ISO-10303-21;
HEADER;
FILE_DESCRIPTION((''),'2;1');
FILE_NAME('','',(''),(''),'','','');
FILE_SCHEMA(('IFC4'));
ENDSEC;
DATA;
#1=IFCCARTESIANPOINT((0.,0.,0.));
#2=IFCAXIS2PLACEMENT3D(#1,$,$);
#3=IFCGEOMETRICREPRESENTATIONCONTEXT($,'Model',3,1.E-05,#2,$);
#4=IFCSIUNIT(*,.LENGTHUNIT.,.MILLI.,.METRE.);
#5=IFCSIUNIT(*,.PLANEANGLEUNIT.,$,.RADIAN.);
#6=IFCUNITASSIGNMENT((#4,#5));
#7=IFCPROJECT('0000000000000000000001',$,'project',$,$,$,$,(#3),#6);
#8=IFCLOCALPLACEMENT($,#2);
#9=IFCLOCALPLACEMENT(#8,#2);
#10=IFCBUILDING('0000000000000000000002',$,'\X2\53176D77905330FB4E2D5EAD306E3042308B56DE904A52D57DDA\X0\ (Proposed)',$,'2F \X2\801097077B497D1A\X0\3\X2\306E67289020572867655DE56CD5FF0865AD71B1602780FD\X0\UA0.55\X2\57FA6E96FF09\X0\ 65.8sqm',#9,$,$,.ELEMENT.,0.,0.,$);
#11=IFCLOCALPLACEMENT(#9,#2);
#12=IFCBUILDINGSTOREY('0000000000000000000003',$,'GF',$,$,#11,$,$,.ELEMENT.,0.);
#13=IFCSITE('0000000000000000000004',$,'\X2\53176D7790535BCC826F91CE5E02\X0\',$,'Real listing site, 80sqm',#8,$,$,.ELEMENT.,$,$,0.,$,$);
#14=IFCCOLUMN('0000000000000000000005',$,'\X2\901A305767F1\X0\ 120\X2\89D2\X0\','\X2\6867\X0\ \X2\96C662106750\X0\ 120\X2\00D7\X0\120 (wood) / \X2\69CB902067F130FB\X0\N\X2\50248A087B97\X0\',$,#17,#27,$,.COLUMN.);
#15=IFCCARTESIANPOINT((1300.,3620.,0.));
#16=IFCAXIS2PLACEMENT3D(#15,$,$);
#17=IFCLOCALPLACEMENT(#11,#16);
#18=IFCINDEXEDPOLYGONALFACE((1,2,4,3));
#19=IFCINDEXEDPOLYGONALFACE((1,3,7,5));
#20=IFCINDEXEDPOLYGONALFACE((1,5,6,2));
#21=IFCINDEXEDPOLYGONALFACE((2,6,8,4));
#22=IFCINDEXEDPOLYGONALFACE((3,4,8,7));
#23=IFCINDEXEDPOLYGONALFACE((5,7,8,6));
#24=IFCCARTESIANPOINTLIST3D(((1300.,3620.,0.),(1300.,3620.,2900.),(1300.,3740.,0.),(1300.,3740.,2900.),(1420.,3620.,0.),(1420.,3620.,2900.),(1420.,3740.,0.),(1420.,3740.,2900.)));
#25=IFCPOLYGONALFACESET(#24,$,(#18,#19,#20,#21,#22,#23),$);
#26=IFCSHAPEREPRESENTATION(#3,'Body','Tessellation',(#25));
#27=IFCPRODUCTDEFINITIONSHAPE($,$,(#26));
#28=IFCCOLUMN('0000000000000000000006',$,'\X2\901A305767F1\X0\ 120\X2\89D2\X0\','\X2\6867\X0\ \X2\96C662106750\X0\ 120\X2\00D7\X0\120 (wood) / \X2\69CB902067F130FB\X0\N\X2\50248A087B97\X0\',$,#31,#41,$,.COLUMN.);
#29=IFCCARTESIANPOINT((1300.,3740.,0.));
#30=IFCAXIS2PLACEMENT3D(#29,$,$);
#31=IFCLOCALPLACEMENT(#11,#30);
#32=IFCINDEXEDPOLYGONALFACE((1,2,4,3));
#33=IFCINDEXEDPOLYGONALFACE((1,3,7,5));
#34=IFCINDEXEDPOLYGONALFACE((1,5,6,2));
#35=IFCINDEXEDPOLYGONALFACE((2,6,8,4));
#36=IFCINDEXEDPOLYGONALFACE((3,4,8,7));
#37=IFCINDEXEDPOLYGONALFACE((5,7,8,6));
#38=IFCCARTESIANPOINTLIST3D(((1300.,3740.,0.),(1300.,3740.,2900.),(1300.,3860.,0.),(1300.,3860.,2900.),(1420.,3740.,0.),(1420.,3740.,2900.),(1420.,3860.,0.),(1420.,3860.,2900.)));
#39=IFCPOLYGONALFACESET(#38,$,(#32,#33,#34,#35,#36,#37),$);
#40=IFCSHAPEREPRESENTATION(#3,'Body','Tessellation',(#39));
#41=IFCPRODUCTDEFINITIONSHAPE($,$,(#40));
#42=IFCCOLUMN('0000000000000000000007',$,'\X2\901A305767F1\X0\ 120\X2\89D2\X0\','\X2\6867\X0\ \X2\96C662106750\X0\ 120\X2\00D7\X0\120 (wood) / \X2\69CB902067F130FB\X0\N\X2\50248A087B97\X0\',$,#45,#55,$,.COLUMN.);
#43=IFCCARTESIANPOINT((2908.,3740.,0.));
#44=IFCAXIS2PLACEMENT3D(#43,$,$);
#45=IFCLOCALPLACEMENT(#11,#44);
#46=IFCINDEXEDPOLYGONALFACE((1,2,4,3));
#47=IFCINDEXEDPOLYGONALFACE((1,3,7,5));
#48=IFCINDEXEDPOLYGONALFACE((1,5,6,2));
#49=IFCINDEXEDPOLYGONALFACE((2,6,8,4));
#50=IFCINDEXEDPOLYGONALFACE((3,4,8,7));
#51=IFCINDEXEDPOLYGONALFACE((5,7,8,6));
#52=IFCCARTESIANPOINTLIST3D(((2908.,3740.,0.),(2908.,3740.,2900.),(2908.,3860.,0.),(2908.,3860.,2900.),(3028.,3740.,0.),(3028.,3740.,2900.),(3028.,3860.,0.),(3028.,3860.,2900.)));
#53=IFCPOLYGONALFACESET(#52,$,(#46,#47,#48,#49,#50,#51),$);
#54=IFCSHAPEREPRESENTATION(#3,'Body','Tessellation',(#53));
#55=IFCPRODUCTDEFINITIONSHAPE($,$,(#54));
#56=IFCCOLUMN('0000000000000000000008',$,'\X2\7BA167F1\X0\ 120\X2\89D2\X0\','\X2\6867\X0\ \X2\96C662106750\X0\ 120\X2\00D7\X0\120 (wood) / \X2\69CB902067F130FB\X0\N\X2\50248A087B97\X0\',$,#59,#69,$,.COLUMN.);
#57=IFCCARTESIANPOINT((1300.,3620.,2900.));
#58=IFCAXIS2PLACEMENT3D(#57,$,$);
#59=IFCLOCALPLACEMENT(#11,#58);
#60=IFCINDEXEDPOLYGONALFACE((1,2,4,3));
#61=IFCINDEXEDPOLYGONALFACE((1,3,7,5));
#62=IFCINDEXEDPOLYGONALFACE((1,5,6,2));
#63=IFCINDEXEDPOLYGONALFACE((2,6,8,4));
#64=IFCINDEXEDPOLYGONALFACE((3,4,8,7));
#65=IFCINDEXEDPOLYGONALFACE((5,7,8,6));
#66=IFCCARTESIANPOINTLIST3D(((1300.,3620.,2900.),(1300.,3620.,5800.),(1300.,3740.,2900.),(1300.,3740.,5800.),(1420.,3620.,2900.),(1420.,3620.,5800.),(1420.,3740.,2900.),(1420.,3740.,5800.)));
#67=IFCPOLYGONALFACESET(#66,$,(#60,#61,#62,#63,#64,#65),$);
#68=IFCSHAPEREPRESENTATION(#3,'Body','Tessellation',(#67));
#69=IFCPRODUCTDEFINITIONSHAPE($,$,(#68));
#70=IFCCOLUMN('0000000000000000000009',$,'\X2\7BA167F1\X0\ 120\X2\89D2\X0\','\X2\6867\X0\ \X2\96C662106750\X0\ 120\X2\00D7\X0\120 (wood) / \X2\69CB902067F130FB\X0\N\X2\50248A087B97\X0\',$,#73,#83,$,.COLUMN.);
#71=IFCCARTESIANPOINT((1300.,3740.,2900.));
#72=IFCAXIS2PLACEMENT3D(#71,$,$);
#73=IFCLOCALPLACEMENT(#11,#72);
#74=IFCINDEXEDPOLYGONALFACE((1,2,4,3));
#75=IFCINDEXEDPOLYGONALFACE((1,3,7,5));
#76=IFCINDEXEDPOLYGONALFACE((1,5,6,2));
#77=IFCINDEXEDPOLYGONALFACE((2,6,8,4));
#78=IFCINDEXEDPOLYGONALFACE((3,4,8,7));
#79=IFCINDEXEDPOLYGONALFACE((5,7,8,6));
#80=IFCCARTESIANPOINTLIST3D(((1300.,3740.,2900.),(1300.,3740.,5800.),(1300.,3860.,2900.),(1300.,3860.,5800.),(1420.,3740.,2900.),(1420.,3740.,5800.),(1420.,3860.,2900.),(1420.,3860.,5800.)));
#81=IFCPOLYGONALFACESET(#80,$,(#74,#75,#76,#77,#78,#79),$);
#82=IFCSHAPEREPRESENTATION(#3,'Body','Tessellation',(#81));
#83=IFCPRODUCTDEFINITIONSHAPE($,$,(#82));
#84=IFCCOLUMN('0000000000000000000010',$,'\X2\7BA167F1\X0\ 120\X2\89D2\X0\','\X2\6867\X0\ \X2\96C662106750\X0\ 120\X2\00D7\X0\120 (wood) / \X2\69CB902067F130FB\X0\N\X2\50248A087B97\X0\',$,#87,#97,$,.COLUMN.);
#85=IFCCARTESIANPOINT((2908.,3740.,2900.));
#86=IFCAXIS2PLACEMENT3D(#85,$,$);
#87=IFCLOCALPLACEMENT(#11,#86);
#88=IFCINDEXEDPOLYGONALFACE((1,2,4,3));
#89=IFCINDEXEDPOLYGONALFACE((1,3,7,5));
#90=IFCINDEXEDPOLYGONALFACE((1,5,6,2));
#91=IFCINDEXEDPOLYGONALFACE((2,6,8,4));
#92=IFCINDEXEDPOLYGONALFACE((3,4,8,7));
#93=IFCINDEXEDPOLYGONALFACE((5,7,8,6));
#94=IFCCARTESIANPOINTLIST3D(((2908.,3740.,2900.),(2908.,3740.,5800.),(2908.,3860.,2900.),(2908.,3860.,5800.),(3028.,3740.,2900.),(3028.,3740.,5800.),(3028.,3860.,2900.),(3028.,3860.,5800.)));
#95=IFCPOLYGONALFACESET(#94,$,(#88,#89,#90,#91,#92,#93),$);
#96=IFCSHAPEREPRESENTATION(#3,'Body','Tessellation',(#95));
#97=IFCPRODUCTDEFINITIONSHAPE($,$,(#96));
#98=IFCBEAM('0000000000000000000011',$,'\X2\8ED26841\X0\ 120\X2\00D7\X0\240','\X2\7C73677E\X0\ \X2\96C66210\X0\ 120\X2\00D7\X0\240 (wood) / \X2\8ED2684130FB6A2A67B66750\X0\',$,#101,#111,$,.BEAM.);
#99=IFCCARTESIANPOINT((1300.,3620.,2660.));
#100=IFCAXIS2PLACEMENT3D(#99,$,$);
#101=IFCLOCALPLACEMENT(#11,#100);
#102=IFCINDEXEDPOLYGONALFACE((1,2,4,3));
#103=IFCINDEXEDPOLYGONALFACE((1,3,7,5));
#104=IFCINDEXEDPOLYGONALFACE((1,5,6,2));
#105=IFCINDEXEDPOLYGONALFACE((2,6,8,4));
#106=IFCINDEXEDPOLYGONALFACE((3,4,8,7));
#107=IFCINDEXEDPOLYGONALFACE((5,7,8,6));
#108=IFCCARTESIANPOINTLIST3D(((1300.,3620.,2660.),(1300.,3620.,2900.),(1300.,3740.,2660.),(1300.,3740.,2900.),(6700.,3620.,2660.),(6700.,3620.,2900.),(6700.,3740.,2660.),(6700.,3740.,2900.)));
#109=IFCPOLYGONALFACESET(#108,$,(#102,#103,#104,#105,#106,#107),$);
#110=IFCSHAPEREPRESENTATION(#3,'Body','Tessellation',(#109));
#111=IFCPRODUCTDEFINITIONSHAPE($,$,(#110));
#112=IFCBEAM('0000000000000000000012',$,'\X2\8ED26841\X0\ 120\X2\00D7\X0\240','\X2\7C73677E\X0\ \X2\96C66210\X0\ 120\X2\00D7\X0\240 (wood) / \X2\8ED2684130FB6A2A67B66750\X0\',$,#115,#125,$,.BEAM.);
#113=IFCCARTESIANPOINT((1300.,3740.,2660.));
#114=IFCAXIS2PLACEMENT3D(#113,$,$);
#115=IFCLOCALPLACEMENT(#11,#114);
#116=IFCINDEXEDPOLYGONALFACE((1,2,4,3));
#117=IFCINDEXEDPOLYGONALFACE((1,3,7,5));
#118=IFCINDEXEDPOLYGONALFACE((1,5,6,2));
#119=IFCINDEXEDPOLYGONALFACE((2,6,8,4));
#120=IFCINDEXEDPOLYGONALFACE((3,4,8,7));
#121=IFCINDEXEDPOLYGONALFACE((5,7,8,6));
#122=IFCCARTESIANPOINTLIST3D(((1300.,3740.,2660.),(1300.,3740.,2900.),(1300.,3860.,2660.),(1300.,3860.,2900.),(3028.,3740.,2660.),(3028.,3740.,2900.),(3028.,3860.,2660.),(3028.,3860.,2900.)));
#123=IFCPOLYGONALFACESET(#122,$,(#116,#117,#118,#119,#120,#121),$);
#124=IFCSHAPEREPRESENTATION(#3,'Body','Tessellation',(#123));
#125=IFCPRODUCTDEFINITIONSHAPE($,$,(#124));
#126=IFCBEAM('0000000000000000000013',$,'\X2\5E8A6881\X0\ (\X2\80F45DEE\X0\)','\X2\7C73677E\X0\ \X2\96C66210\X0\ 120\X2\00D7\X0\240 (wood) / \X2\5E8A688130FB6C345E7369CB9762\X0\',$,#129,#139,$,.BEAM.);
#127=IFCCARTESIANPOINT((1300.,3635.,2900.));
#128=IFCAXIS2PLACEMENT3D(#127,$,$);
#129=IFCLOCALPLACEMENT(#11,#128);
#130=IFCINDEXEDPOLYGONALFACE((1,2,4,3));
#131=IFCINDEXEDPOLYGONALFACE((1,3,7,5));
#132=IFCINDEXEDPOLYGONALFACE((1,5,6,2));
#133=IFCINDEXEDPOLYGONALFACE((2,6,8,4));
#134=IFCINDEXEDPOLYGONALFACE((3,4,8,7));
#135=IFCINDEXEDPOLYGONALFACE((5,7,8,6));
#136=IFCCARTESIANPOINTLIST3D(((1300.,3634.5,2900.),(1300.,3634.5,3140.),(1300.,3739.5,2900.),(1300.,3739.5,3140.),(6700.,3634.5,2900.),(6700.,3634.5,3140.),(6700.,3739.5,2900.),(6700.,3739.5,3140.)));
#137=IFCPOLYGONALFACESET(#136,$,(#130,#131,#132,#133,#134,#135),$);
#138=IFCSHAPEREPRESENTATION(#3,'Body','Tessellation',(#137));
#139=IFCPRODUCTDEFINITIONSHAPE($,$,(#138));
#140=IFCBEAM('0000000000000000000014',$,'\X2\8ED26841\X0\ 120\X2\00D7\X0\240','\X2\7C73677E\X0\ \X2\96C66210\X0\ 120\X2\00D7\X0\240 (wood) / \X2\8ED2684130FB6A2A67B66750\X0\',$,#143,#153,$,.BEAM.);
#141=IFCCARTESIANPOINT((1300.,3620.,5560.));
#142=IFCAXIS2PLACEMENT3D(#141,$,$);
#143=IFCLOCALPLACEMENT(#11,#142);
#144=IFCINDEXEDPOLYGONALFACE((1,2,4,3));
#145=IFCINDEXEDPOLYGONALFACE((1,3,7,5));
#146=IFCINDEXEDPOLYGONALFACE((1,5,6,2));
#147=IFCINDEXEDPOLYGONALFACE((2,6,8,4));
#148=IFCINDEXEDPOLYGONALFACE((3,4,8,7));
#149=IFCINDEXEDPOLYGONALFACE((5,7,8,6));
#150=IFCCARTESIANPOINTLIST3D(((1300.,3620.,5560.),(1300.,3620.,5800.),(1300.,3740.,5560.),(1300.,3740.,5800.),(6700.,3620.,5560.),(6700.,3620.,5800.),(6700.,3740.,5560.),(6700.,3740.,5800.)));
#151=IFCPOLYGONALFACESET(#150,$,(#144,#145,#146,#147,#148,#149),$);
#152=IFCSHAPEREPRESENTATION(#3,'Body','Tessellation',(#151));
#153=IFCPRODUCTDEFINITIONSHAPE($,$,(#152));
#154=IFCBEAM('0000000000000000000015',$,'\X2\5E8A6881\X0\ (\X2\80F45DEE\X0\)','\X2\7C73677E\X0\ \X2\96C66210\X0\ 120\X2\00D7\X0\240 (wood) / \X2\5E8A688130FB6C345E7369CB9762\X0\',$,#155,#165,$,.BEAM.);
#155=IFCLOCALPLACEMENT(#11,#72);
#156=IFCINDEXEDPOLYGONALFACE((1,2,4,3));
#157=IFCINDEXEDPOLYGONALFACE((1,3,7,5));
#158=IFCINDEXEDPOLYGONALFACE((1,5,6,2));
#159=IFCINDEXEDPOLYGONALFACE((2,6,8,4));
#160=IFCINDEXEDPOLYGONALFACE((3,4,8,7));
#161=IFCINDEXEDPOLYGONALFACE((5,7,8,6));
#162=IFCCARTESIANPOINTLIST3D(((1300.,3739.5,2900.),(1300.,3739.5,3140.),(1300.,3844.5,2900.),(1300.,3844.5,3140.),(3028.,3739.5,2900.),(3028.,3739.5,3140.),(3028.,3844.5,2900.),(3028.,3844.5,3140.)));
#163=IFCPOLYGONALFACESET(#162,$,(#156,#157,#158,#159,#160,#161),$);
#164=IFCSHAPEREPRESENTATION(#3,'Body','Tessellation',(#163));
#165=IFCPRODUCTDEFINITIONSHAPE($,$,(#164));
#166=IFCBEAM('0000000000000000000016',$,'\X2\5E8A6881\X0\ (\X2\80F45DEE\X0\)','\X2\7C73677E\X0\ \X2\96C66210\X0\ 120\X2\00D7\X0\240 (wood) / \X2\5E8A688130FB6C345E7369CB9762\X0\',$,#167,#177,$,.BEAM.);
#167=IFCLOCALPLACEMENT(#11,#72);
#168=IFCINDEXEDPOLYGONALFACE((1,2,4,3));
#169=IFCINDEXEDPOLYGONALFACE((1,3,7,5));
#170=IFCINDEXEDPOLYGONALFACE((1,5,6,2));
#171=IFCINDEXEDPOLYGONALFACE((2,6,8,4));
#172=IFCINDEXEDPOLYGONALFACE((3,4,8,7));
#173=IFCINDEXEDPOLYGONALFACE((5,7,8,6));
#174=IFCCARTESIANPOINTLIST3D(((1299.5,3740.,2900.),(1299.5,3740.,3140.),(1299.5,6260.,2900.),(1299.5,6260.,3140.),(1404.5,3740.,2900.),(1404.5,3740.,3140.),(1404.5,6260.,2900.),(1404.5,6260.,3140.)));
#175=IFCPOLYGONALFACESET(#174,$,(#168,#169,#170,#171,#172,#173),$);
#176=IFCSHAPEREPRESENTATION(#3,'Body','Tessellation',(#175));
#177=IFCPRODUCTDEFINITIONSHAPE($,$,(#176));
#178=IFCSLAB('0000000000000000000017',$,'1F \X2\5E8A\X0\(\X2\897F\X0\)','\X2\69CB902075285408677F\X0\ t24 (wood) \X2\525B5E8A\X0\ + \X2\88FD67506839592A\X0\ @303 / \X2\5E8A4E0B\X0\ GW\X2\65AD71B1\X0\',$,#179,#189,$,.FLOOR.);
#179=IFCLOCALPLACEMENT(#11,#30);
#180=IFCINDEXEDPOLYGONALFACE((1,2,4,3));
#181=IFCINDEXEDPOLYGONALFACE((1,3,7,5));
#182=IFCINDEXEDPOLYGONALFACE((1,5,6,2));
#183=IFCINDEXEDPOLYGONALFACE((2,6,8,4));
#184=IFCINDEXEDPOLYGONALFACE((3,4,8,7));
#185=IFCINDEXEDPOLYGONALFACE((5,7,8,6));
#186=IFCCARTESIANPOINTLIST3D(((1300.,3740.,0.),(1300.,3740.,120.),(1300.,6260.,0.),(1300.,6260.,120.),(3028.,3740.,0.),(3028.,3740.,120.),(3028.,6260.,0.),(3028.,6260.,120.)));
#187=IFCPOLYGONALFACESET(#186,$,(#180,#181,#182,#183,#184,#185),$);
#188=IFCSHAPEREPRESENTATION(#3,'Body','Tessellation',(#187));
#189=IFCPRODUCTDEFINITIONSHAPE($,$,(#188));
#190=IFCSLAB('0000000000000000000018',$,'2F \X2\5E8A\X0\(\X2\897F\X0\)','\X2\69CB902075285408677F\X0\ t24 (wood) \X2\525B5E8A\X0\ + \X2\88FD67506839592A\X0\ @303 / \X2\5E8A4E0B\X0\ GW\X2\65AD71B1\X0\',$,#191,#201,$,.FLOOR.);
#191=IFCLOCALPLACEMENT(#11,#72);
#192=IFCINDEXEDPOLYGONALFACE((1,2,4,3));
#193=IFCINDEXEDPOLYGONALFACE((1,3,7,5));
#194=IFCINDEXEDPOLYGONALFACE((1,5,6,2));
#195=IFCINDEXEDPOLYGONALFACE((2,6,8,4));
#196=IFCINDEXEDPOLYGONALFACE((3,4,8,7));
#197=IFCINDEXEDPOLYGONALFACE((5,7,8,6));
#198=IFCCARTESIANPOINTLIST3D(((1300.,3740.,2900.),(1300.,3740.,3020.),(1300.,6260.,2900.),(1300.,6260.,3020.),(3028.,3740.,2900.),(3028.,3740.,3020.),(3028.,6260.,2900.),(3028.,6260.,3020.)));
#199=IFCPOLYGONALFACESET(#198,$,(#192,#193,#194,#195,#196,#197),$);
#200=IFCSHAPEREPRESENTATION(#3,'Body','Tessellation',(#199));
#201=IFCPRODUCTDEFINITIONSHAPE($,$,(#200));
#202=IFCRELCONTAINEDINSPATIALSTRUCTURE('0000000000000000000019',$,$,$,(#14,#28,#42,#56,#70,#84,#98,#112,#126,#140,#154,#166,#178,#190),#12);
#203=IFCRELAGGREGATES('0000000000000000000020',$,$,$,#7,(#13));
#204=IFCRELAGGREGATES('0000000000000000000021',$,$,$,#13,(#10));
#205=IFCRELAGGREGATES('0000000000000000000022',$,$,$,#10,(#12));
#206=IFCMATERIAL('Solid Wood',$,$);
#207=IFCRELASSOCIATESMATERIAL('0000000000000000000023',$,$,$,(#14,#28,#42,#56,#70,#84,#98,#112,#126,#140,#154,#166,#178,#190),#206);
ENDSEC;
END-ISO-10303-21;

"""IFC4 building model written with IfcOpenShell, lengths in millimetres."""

from ifc_helpers import new_model, si_unit, frame, frame_2d, origin, place, context, project, spatial, rectangle, extrude, material, element, save


model = new_model("IFC4")

# Units and contexts
model_context = context("Model", 3, precision=1e-05, world=origin())
ifc_project = project(units=[si_unit("LENGTHUNIT", "METRE", prefix="MILLI"), si_unit("PLANEANGLEUNIT", "RADIAN")], contexts=[model_context])

# Site, building, storey
site_placement = place(None, origin())
site = spatial("IfcSite", under=ifc_project, at=site_placement, Name="北海道富良野市", ObjectType="Real listing site, 80sqm", CompositionType="ELEMENT", RefElevation=0.0)
building_placement = place(site_placement, origin())
building = spatial("IfcBuilding", under=site, at=building_placement, Name="北海道・中庭のある回遊動線 (Proposed)", ObjectType="2F 耐震等級3の木造在来工法（断熱性能UA0.55基準） 65.8sqm", CompositionType="ELEMENT", ElevationOfRefHeight=0.0, ElevationOfTerrain=0.0)
storey_placement = place(building_placement, origin())
storey = spatial("IfcBuildingStorey", under=building, at=storey_placement, Name="GF", CompositionType="ELEMENT", Elevation=0.0)

# Columns
ifc_material_1 = material(Name="Solid Wood")
column_1_placement = place(storey_placement, frame((1300.0, 3620.0, 0.0)))
element("IfcColumn", 1, at=column_1_placement, inside=storey, material=ifc_material_1, Name="通し柱 120角", Description="桧 集成材 120×120 (wood) / 構造柱・N値計算", PredefinedType="COLUMN", context=model_context, shape_type="SweptSolid", body=[
    extrude(rectangle(XDim=120.0, YDim=120.0, at=frame_2d((60.0, 60.0))), frame((1300.0, 3620.0, 0.0)), (0.0, 0.0, 1.0), 2900.0),
])
column_2_placement = place(storey_placement, frame((1300.0, 3740.0, 0.0)))
element("IfcColumn", 2, at=column_2_placement, inside=storey, material=ifc_material_1, Name="通し柱 120角", Description="桧 集成材 120×120 (wood) / 構造柱・N値計算", PredefinedType="COLUMN", context=model_context, shape_type="SweptSolid", body=[
    extrude(rectangle(XDim=120.0, YDim=120.0, at=frame_2d((60.0, 60.0))), frame((1300.0, 3740.0, 0.0)), (0.0, 0.0, 1.0), 2900.0),
])
column_3_placement = place(storey_placement, frame((2908.0, 3740.0, 0.0)))
element("IfcColumn", 3, at=column_3_placement, inside=storey, material=ifc_material_1, Name="通し柱 120角", Description="桧 集成材 120×120 (wood) / 構造柱・N値計算", PredefinedType="COLUMN", context=model_context, shape_type="SweptSolid", body=[
    extrude(rectangle(XDim=120.0, YDim=120.0, at=frame_2d((60.0, 60.0))), frame((2908.0, 3740.0, 0.0)), (0.0, 0.0, 1.0), 2900.0),
])
column_4_placement = place(storey_placement, frame((1300.0, 3620.0, 2900.0)))
element("IfcColumn", 4, at=column_4_placement, inside=storey, material=ifc_material_1, Name="管柱 120角", Description="桧 集成材 120×120 (wood) / 構造柱・N値計算", PredefinedType="COLUMN", context=model_context, shape_type="SweptSolid", body=[
    extrude(rectangle(XDim=120.0, YDim=120.0, at=frame_2d((60.0, 60.0))), frame((1300.0, 3620.0, 2900.0)), (0.0, 0.0, 1.0), 2900.0),
])
column_5_placement = place(storey_placement, frame((1300.0, 3740.0, 2900.0)))
element("IfcColumn", 5, at=column_5_placement, inside=storey, material=ifc_material_1, Name="管柱 120角", Description="桧 集成材 120×120 (wood) / 構造柱・N値計算", PredefinedType="COLUMN", context=model_context, shape_type="SweptSolid", body=[
    extrude(rectangle(XDim=120.0, YDim=120.0, at=frame_2d((60.0, 60.0))), frame((1300.0, 3740.0, 2900.0)), (0.0, 0.0, 1.0), 2900.0),
])
column_6_placement = place(storey_placement, frame((2908.0, 3740.0, 2900.0)))
element("IfcColumn", 6, at=column_6_placement, inside=storey, material=ifc_material_1, Name="管柱 120角", Description="桧 集成材 120×120 (wood) / 構造柱・N値計算", PredefinedType="COLUMN", context=model_context, shape_type="SweptSolid", body=[
    extrude(rectangle(XDim=120.0, YDim=120.0, at=frame_2d((60.0, 60.0))), frame((2908.0, 3740.0, 2900.0)), (0.0, 0.0, 1.0), 2900.0),
])

# Beams
beam_1_placement = place(storey_placement, frame((1300.0, 3620.0, 2660.0)))
element("IfcBeam", 7, at=beam_1_placement, inside=storey, material=ifc_material_1, Name="軒桁 120×240", Description="米松 集成 120×240 (wood) / 軒桁・横架材", PredefinedType="BEAM", context=model_context, shape_type="SweptSolid", body=[
    extrude(rectangle(XDim=5400.0, YDim=120.0, at=frame_2d((2700.0, 60.0))), frame((1300.0, 3620.0, 2660.0)), (0.0, 0.0, 1.0), 240.0),
])
beam_2_placement = place(storey_placement, frame((1300.0, 3740.0, 2660.0)))
element("IfcBeam", 8, at=beam_2_placement, inside=storey, material=ifc_material_1, Name="軒桁 120×240", Description="米松 集成 120×240 (wood) / 軒桁・横架材", PredefinedType="BEAM", context=model_context, shape_type="SweptSolid", body=[
    extrude(rectangle(XDim=1728.0, YDim=120.0, at=frame_2d((864.0, 60.0))), frame((1300.0, 3740.0, 2660.0)), (0.0, 0.0, 1.0), 240.0),
])
beam_3_placement = place(storey_placement, frame((1300.0, 3635.0, 2900.0)))
element("IfcBeam", 9, at=beam_3_placement, inside=storey, material=ifc_material_1, Name="床梁 (胴差)", Description="米松 集成 120×240 (wood) / 床梁・水平構面", PredefinedType="BEAM", context=model_context, shape_type="SweptSolid", body=[
    extrude(rectangle(XDim=5400.0, YDim=105.0, at=frame_2d((2700.0, 52.0))), frame((1300.0, 3635.0, 2900.0)), (0.0, 0.0, 1.0), 240.0),
])
beam_4_placement = place(storey_placement, frame((1300.0, 3620.0, 5560.0)))
element("IfcBeam", 10, at=beam_4_placement, inside=storey, material=ifc_material_1, Name="軒桁 120×240", Description="米松 集成 120×240 (wood) / 軒桁・横架材", PredefinedType="BEAM", context=model_context, shape_type="SweptSolid", body=[
    extrude(rectangle(XDim=5400.0, YDim=120.0, at=frame_2d((2700.0, 60.0))), frame((1300.0, 3620.0, 5560.0)), (0.0, 0.0, 1.0), 240.0),
])
beam_5_placement = place(storey_placement, frame((1300.0, 3740.0, 2900.0)))
element("IfcBeam", 11, at=beam_5_placement, inside=storey, material=ifc_material_1, Name="床梁 (胴差)", Description="米松 集成 120×240 (wood) / 床梁・水平構面", PredefinedType="BEAM", context=model_context, shape_type="SweptSolid", body=[
    extrude(rectangle(XDim=1728.0, YDim=105.0, at=frame_2d((864.0, 52.0))), frame((1300.0, 3740.0, 2900.0)), (0.0, 0.0, 1.0), 240.0),
])
beam_6_placement = place(storey_placement, frame((1300.0, 3740.0, 2900.0)))
element("IfcBeam", 12, at=beam_6_placement, inside=storey, material=ifc_material_1, Name="床梁 (胴差)", Description="米松 集成 120×240 (wood) / 床梁・水平構面", PredefinedType="BEAM", context=model_context, shape_type="SweptSolid", body=[
    extrude(rectangle(XDim=105.0, YDim=2520.0, at=frame_2d((52.0, 1260.0))), frame((1300.0, 3740.0, 2900.0)), (0.0, 0.0, 1.0), 240.0),
])

# Slabs
slab_1_placement = place(storey_placement, frame((1300.0, 3740.0, 0.0)))
element("IfcSlab", 13, at=slab_1_placement, inside=storey, material=ifc_material_1, Name="1F 床(西)", Description="構造用合板 t24 (wood) 剛床 + 製材根太 @303 / 床下 GW断熱", PredefinedType="FLOOR", context=model_context, shape_type="SweptSolid", body=[
    extrude(rectangle(XDim=1728.0, YDim=2520.0, at=frame_2d((864.0, 1260.0))), frame((1300.0, 3740.0, 0.0)), (0.0, 0.0, 1.0), 120.0),
])
slab_2_placement = place(storey_placement, frame((1300.0, 3740.0, 2900.0)))
element("IfcSlab", 14, at=slab_2_placement, inside=storey, material=ifc_material_1, Name="2F 床(西)", Description="構造用合板 t24 (wood) 剛床 + 製材根太 @303 / 床下 GW断熱", PredefinedType="FLOOR", context=model_context, shape_type="SweptSolid", body=[
    extrude(rectangle(XDim=1728.0, YDim=2520.0, at=frame_2d((864.0, 1260.0))), frame((1300.0, 3740.0, 2900.0)), (0.0, 0.0, 1.0), 120.0),
])

save(model, "model.ifc")
